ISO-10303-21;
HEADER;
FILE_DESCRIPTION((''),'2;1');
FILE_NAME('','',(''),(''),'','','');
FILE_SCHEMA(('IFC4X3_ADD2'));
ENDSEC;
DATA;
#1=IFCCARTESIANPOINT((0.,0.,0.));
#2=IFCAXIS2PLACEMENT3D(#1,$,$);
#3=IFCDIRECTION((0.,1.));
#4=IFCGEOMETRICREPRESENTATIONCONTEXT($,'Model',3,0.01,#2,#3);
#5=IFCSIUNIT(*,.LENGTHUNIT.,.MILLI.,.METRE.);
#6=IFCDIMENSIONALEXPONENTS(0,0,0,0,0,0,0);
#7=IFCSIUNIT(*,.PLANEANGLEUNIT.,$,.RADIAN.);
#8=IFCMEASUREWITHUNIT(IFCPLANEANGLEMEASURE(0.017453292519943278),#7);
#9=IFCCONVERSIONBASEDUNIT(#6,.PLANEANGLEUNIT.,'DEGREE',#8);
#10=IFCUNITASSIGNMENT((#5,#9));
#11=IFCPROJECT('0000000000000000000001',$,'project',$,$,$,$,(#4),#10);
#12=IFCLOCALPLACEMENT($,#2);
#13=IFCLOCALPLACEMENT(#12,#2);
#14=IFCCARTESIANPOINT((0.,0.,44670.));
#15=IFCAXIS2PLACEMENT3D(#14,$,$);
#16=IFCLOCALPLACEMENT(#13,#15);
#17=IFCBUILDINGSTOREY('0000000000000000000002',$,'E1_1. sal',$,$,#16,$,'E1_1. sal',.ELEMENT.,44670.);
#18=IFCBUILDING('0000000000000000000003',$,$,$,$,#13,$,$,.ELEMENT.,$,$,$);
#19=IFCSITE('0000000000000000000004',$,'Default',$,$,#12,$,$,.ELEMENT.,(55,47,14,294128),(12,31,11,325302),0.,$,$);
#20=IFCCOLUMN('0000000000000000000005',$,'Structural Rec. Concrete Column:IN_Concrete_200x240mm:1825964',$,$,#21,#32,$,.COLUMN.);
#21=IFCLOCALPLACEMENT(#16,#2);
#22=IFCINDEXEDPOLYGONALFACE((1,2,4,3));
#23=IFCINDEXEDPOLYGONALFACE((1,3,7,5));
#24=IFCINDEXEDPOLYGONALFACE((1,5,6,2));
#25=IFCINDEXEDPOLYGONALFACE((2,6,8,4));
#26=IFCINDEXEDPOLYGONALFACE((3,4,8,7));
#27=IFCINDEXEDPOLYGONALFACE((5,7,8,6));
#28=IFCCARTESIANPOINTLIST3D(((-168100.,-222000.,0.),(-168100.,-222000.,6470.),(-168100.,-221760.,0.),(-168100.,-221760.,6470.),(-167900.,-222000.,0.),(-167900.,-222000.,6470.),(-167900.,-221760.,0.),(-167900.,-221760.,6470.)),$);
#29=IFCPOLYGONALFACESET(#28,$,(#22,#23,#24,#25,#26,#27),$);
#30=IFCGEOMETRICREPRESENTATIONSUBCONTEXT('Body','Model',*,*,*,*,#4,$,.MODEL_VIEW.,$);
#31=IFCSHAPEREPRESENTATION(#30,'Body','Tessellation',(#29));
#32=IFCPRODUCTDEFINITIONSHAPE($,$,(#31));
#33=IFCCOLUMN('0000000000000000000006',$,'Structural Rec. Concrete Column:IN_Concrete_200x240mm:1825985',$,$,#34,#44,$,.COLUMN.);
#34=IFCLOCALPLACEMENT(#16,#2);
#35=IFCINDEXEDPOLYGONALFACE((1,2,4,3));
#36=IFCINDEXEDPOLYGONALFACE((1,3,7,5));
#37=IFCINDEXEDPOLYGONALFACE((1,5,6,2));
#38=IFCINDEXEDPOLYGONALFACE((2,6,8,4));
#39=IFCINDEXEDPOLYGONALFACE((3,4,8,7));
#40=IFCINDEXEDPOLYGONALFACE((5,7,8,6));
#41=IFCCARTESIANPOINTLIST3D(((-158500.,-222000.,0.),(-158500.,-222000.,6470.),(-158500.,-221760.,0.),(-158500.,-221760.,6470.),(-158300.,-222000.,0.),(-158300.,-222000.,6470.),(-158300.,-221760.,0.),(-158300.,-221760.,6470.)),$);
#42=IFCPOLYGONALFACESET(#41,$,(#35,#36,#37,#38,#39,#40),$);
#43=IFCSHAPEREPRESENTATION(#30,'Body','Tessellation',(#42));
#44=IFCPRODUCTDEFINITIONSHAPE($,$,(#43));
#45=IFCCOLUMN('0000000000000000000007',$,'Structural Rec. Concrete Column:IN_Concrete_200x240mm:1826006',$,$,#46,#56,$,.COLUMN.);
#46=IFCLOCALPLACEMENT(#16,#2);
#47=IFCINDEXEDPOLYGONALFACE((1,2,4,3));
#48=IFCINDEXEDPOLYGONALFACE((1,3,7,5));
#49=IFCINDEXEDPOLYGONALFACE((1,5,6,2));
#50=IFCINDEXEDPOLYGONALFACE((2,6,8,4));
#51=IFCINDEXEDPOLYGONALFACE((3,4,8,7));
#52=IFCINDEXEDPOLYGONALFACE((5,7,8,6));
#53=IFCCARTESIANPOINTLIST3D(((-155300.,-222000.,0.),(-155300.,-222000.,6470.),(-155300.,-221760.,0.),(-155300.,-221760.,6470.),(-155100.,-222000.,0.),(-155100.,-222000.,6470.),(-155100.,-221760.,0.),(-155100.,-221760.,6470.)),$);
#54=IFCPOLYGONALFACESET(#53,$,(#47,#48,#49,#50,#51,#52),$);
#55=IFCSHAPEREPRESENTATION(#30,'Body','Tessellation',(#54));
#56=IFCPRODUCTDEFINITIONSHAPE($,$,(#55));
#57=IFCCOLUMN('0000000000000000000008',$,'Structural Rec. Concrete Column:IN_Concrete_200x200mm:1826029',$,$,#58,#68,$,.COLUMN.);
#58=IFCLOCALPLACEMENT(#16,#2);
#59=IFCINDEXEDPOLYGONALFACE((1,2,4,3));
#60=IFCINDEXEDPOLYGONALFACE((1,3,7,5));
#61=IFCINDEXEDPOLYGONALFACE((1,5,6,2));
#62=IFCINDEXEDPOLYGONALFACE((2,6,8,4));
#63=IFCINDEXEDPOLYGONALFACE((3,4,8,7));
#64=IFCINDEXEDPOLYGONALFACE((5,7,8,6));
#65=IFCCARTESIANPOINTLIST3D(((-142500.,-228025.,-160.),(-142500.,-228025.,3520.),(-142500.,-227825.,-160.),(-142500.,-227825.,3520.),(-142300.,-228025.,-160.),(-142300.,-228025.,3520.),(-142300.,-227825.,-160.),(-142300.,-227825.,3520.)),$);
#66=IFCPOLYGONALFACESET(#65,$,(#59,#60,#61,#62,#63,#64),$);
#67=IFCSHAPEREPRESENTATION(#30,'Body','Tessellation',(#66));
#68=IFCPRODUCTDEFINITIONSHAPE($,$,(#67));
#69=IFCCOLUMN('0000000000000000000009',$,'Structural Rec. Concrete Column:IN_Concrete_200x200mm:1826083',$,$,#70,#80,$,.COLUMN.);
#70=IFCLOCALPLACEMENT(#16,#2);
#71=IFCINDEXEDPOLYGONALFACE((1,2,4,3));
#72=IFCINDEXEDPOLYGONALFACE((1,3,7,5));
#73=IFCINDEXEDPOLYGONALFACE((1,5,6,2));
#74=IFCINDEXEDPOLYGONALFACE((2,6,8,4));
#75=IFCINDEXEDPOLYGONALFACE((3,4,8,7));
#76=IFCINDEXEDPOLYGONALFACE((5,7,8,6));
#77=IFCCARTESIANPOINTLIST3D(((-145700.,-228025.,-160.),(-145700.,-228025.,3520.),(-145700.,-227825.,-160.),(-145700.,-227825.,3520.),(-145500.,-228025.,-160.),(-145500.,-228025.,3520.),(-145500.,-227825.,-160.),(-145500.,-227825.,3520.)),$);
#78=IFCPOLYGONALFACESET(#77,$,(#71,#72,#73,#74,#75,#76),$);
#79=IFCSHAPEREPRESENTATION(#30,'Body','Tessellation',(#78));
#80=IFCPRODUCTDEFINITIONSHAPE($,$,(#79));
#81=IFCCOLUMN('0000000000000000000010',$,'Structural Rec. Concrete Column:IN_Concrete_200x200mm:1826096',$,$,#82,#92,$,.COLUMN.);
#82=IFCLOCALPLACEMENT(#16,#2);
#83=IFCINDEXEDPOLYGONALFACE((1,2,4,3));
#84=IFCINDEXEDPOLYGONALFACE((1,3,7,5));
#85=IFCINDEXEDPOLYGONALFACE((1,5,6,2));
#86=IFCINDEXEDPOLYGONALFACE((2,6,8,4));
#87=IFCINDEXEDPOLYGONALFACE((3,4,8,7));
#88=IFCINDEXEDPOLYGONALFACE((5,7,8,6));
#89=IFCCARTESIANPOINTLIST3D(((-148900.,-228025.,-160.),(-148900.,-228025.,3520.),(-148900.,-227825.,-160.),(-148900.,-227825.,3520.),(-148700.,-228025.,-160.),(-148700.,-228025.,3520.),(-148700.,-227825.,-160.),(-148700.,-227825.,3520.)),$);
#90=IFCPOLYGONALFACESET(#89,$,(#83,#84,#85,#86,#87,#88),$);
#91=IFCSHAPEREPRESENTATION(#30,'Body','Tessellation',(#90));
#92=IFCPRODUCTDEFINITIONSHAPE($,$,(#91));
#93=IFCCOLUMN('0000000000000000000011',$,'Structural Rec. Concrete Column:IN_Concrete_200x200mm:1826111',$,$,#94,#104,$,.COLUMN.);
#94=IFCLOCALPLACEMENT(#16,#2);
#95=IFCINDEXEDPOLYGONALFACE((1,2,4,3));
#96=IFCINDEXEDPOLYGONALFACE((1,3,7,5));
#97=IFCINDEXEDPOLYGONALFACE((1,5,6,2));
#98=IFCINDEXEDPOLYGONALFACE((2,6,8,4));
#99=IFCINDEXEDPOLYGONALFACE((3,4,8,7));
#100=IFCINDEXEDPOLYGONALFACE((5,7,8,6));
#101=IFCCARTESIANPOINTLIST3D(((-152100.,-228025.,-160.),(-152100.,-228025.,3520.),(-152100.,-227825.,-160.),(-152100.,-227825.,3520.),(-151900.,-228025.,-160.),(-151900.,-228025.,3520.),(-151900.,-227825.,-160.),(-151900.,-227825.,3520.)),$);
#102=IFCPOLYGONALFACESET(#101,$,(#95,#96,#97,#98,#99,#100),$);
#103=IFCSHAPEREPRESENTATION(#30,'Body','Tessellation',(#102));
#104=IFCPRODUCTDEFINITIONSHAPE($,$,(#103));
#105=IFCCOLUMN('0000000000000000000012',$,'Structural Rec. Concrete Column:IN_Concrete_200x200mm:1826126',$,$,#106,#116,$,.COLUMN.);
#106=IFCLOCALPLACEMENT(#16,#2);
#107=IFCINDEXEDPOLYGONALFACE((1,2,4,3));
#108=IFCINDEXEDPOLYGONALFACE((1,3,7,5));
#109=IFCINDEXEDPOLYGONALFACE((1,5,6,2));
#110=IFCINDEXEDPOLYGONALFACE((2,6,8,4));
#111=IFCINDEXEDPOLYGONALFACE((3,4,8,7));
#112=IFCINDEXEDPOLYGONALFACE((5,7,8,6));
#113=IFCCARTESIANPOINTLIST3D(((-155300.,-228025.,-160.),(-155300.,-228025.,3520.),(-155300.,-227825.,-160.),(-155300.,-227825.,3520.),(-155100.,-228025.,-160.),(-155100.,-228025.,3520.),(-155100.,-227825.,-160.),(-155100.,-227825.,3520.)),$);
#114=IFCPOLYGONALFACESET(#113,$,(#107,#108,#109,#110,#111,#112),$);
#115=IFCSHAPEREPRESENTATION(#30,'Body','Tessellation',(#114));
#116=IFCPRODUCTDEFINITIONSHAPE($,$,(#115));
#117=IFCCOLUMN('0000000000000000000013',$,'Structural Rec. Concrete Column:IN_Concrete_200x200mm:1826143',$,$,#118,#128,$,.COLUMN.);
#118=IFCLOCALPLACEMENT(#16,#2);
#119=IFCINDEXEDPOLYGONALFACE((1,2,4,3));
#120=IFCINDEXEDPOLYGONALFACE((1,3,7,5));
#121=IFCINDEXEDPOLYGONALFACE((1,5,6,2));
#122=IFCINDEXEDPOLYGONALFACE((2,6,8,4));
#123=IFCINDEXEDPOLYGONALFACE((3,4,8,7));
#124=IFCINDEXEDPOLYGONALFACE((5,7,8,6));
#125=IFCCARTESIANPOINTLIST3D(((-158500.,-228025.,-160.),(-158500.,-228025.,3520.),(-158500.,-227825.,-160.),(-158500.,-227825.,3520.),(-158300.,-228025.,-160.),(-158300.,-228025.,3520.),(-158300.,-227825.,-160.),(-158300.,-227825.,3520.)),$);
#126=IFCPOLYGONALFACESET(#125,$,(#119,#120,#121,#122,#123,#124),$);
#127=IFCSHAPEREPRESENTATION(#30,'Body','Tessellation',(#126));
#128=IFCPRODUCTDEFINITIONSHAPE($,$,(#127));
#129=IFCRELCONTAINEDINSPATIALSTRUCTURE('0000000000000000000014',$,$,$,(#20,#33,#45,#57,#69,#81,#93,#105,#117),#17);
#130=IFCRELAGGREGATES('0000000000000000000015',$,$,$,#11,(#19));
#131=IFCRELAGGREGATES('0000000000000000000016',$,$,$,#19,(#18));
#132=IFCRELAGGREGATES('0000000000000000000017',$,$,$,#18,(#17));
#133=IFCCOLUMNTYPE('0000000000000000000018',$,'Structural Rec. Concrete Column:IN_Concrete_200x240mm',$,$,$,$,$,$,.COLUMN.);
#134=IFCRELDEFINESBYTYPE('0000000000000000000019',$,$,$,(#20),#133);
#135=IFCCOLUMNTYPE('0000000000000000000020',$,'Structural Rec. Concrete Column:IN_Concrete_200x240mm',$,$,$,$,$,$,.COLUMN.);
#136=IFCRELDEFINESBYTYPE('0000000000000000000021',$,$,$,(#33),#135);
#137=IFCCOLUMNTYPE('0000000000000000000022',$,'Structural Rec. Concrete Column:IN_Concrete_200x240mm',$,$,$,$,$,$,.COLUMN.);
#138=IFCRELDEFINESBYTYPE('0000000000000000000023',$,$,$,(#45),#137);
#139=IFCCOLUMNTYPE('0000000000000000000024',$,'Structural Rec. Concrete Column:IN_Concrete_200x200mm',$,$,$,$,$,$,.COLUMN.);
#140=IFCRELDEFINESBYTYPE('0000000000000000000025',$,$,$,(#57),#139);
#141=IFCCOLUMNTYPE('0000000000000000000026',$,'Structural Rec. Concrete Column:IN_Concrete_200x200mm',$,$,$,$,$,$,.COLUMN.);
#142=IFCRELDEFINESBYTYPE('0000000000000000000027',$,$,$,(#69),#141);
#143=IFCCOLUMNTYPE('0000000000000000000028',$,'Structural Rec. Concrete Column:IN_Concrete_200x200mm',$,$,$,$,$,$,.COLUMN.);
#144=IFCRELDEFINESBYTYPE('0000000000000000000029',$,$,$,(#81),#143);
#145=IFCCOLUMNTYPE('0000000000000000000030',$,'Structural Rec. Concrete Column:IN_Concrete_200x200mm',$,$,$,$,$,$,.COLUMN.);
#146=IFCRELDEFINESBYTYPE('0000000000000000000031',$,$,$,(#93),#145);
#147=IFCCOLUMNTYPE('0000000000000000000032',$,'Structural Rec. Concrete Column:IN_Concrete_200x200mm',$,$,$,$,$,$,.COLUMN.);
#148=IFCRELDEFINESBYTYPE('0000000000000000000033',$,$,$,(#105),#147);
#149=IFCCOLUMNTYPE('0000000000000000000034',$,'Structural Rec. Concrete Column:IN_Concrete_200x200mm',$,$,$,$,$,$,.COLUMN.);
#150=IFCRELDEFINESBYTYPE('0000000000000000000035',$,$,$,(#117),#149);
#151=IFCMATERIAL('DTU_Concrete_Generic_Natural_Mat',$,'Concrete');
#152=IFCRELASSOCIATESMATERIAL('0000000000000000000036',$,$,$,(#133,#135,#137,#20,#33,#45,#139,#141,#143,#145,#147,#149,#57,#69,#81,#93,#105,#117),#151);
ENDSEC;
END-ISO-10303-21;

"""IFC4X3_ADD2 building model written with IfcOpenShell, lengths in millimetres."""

from ifc_helpers import new_model, entity, si_unit, converted_unit, direction, frame, frame_2d, origin, place, context, subcontext, project, spatial, rectangle, extrude, source, transform, mapped, material, material_profile, profile_set, profile_usage, type_object, type_shapes, element, save


model = new_model("IFC4X3_ADD2")

# Units and contexts
model_context = context("Model", 3, precision=0.01, world=origin(), true_north=direction((0.0, 1.0)))
body_context = subcontext(model_context, "Body", "Model", "MODEL_VIEW")
ifc_project = project(units=[si_unit("LENGTHUNIT", "METRE", prefix="MILLI"), converted_unit("PLANEANGLEUNIT", "DEGREE", entity("IfcPlaneAngleMeasure", 0.017453292519943278), si_unit("PLANEANGLEUNIT", "RADIAN"), dimensions=[0, 0, 0, 0, 0, 0, 0])], contexts=[model_context])

# Site, building, storey
site_placement = place(None, origin())
site = spatial("IfcSite", under=ifc_project, at=site_placement, Name="Default", CompositionType="ELEMENT", RefLatitude=(55, 47, 14, 294128), RefLongitude=(12, 31, 11, 325302), RefElevation=0.0)
building_placement = place(site_placement, origin())
building = spatial("IfcBuilding", under=site, at=building_placement, CompositionType="ELEMENT")
storey_placement = place(building_placement, frame((0.0, 0.0, 44670.0)))
storey = spatial("IfcBuildingStorey", under=building, at=storey_placement, Name="E1_1. sal", LongName="E1_1. sal", CompositionType="ELEMENT", Elevation=44670.0)

# Columns
ifc_material = material(Name="DTU_Concrete_Generic_Natural_Mat", Category="Concrete")
ifc_material_profile_1 = material_profile(ifc_material, rectangle(XDim=200.0, YDim=240.0, at=frame_2d((0.0, 0.0), x_axis=(1.0, 0.0))), Name="IN_Concrete_200x240mm")
ifc_profile_set_1 = profile_set([ifc_material_profile_1], Name="IN_Concrete_200x240mm")
ifc_profile_usage_1 = profile_usage(ifc_profile_set_1)
column_type_1 = type_object("IfcColumnType", Name="Structural Rec. Concrete Column:IN_Concrete_200x240mm", PredefinedType="COLUMN", material=ifc_profile_set_1)
shared_shape_1 = source(origin(), body_context, "Body", "SweptSolid", [
    extrude(rectangle(XDim=200.0, YDim=240.0, at=frame_2d((0.0, 0.0), x_axis=(1.0, 0.0))), frame((-168000.0, -221880.0, 44670.0), z_axis=(0.0, 0.0, 1.0), x_axis=(-1.0, 0.0, 0.0)), (0.0, 0.0, 1.0), 6470.0),
])
type_shapes(column_type_1, [shared_shape_1])
column_1_placement = place(storey_placement, frame((0.0, 0.0, -44670.0)))
element("IfcColumn", 1, at=column_1_placement, inside=storey, type_object=column_type_1, material=ifc_profile_usage_1, Name="Structural Rec. Concrete Column:IN_Concrete_200x240mm:1825964", PredefinedType="COLUMN", context=body_context, shape_type="MappedRepresentation", body=[
    mapped(shared_shape_1, transform((0.0, 0.0, 0.0), scale=1.0)),
])
column_type_2 = type_object("IfcColumnType", Name="Structural Rec. Concrete Column:IN_Concrete_200x240mm", PredefinedType="COLUMN", material=ifc_profile_set_1)
shared_shape_2 = source(origin(), body_context, "Body", "SweptSolid", [
    extrude(rectangle(XDim=200.0, YDim=240.0, at=frame_2d((0.0, 0.0), x_axis=(1.0, 0.0))), frame((-158400.0, -221880.0, 44670.0), z_axis=(0.0, 0.0, 1.0), x_axis=(-1.0, 0.0, 0.0)), (0.0, 0.0, 1.0), 6470.0),
])
type_shapes(column_type_2, [shared_shape_2])
column_2_placement = place(storey_placement, frame((0.0, 0.0, -44670.0)))
element("IfcColumn", 2, at=column_2_placement, inside=storey, type_object=column_type_2, material=ifc_profile_usage_1, Name="Structural Rec. Concrete Column:IN_Concrete_200x240mm:1825985", PredefinedType="COLUMN", context=body_context, shape_type="MappedRepresentation", body=[
    mapped(shared_shape_2, transform((0.0, 0.0, 0.0), scale=1.0)),
])
column_type_3 = type_object("IfcColumnType", Name="Structural Rec. Concrete Column:IN_Concrete_200x240mm", PredefinedType="COLUMN", material=ifc_profile_set_1)
shared_shape_3 = source(origin(), body_context, "Body", "SweptSolid", [
    extrude(rectangle(XDim=200.0, YDim=240.0, at=frame_2d((0.0, 0.0), x_axis=(1.0, 0.0))), frame((-155200.0, -221880.0, 44670.0), z_axis=(0.0, 0.0, 1.0), x_axis=(-1.0, 0.0, 0.0)), (0.0, 0.0, 1.0), 6470.0),
])
type_shapes(column_type_3, [shared_shape_3])
column_3_placement = place(storey_placement, frame((0.0, 0.0, -44670.0)))
element("IfcColumn", 3, at=column_3_placement, inside=storey, type_object=column_type_3, material=ifc_profile_usage_1, Name="Structural Rec. Concrete Column:IN_Concrete_200x240mm:1826006", PredefinedType="COLUMN", context=body_context, shape_type="MappedRepresentation", body=[
    mapped(shared_shape_3, transform((0.0, 0.0, 0.0), scale=1.0)),
])
ifc_material_profile_2 = material_profile(ifc_material, rectangle(XDim=200.0, YDim=200.0, at=frame_2d((0.0, 0.0), x_axis=(1.0, 0.0))), Name="IN_Concrete_200x200mm")
ifc_profile_set_2 = profile_set([ifc_material_profile_2], Name="IN_Concrete_200x200mm")
ifc_profile_usage_2 = profile_usage(ifc_profile_set_2)
column_type_4 = type_object("IfcColumnType", Name="Structural Rec. Concrete Column:IN_Concrete_200x200mm", PredefinedType="COLUMN", material=ifc_profile_set_2)
shared_shape_4 = source(origin(), body_context, "Body", "SweptSolid", [
    extrude(rectangle(XDim=200.0, YDim=200.0, at=frame_2d((0.0, 0.0), x_axis=(1.0, 0.0))), frame((-142400.0, -227925.0, 44510.0), z_axis=(0.0, 0.0, 1.0), x_axis=(-1.0, 0.0, 0.0)), (0.0, 0.0, 1.0), 3680.0),
])
type_shapes(column_type_4, [shared_shape_4])
column_4_placement = place(storey_placement, frame((0.0, 0.0, -44670.0)))
element("IfcColumn", 4, at=column_4_placement, inside=storey, type_object=column_type_4, material=ifc_profile_usage_2, Name="Structural Rec. Concrete Column:IN_Concrete_200x200mm:1826029", PredefinedType="COLUMN", context=body_context, shape_type="MappedRepresentation", body=[
    mapped(shared_shape_4, transform((0.0, 0.0, 0.0), scale=1.0)),
])
column_type_5 = type_object("IfcColumnType", Name="Structural Rec. Concrete Column:IN_Concrete_200x200mm", PredefinedType="COLUMN", material=ifc_profile_set_2)
shared_shape_5 = source(origin(), body_context, "Body", "SweptSolid", [
    extrude(rectangle(XDim=200.0, YDim=200.0, at=frame_2d((0.0, 0.0), x_axis=(1.0, 0.0))), frame((-145600.0, -227925.0, 44510.0), z_axis=(0.0, 0.0, 1.0), x_axis=(-1.0, 0.0, 0.0)), (0.0, 0.0, 1.0), 3680.0),
])
type_shapes(column_type_5, [shared_shape_5])
column_5_placement = place(storey_placement, frame((0.0, 0.0, -44670.0)))
element("IfcColumn", 5, at=column_5_placement, inside=storey, type_object=column_type_5, material=ifc_profile_usage_2, Name="Structural Rec. Concrete Column:IN_Concrete_200x200mm:1826083", PredefinedType="COLUMN", context=body_context, shape_type="MappedRepresentation", body=[
    mapped(shared_shape_5, transform((0.0, 0.0, 0.0), scale=1.0)),
])
column_type_6 = type_object("IfcColumnType", Name="Structural Rec. Concrete Column:IN_Concrete_200x200mm", PredefinedType="COLUMN", material=ifc_profile_set_2)
shared_shape_6 = source(origin(), body_context, "Body", "SweptSolid", [
    extrude(rectangle(XDim=200.0, YDim=200.0, at=frame_2d((0.0, 0.0), x_axis=(1.0, 0.0))), frame((-148800.0, -227925.0, 44510.0), z_axis=(0.0, 0.0, 1.0), x_axis=(-1.0, 0.0, 0.0)), (0.0, 0.0, 1.0), 3680.0),
])
type_shapes(column_type_6, [shared_shape_6])
column_6_placement = place(storey_placement, frame((0.0, 0.0, -44670.0)))
element("IfcColumn", 6, at=column_6_placement, inside=storey, type_object=column_type_6, material=ifc_profile_usage_2, Name="Structural Rec. Concrete Column:IN_Concrete_200x200mm:1826096", PredefinedType="COLUMN", context=body_context, shape_type="MappedRepresentation", body=[
    mapped(shared_shape_6, transform((0.0, 0.0, 0.0), scale=1.0)),
])
column_type_7 = type_object("IfcColumnType", Name="Structural Rec. Concrete Column:IN_Concrete_200x200mm", PredefinedType="COLUMN", material=ifc_profile_set_2)
shared_shape_7 = source(origin(), body_context, "Body", "SweptSolid", [
    extrude(rectangle(XDim=200.0, YDim=200.0, at=frame_2d((0.0, 0.0), x_axis=(1.0, 0.0))), frame((-152000.0, -227925.0, 44510.0), z_axis=(0.0, 0.0, 1.0), x_axis=(-1.0, 0.0, 0.0)), (0.0, 0.0, 1.0), 3680.0),
])
type_shapes(column_type_7, [shared_shape_7])
column_7_placement = place(storey_placement, frame((0.0, 0.0, -44670.0)))
element("IfcColumn", 7, at=column_7_placement, inside=storey, type_object=column_type_7, material=ifc_profile_usage_2, Name="Structural Rec. Concrete Column:IN_Concrete_200x200mm:1826111", PredefinedType="COLUMN", context=body_context, shape_type="MappedRepresentation", body=[
    mapped(shared_shape_7, transform((0.0, 0.0, 0.0), scale=1.0)),
])
column_type_8 = type_object("IfcColumnType", Name="Structural Rec. Concrete Column:IN_Concrete_200x200mm", PredefinedType="COLUMN", material=ifc_profile_set_2)
shared_shape_8 = source(origin(), body_context, "Body", "SweptSolid", [
    extrude(rectangle(XDim=200.0, YDim=200.0, at=frame_2d((0.0, 0.0), x_axis=(1.0, 0.0))), frame((-155200.0, -227925.0, 44510.0), z_axis=(0.0, 0.0, 1.0), x_axis=(-1.0, 0.0, 0.0)), (0.0, 0.0, 1.0), 3680.0),
])
type_shapes(column_type_8, [shared_shape_8])
column_8_placement = place(storey_placement, frame((0.0, 0.0, -44670.0)))
element("IfcColumn", 8, at=column_8_placement, inside=storey, type_object=column_type_8, material=ifc_profile_usage_2, Name="Structural Rec. Concrete Column:IN_Concrete_200x200mm:1826126", PredefinedType="COLUMN", context=body_context, shape_type="MappedRepresentation", body=[
    mapped(shared_shape_8, transform((0.0, 0.0, 0.0), scale=1.0)),
])
column_type_9 = type_object("IfcColumnType", Name="Structural Rec. Concrete Column:IN_Concrete_200x200mm", PredefinedType="COLUMN", material=ifc_profile_set_2)
shared_shape_9 = source(origin(), body_context, "Body", "SweptSolid", [
    extrude(rectangle(XDim=200.0, YDim=200.0, at=frame_2d((0.0, 0.0), x_axis=(1.0, 0.0))), frame((-158400.0, -227925.0, 44510.0), z_axis=(0.0, 0.0, 1.0), x_axis=(-1.0, 0.0, 0.0)), (0.0, 0.0, 1.0), 3680.0),
])
type_shapes(column_type_9, [shared_shape_9])
column_9_placement = place(storey_placement, frame((0.0, 0.0, -44670.0)))
element("IfcColumn", 9, at=column_9_placement, inside=storey, type_object=column_type_9, material=ifc_profile_usage_2, Name="Structural Rec. Concrete Column:IN_Concrete_200x200mm:1826143", PredefinedType="COLUMN", context=body_context, shape_type="MappedRepresentation", body=[
    mapped(shared_shape_9, transform((0.0, 0.0, 0.0), scale=1.0)),
])

save(model, "model.ifc")
